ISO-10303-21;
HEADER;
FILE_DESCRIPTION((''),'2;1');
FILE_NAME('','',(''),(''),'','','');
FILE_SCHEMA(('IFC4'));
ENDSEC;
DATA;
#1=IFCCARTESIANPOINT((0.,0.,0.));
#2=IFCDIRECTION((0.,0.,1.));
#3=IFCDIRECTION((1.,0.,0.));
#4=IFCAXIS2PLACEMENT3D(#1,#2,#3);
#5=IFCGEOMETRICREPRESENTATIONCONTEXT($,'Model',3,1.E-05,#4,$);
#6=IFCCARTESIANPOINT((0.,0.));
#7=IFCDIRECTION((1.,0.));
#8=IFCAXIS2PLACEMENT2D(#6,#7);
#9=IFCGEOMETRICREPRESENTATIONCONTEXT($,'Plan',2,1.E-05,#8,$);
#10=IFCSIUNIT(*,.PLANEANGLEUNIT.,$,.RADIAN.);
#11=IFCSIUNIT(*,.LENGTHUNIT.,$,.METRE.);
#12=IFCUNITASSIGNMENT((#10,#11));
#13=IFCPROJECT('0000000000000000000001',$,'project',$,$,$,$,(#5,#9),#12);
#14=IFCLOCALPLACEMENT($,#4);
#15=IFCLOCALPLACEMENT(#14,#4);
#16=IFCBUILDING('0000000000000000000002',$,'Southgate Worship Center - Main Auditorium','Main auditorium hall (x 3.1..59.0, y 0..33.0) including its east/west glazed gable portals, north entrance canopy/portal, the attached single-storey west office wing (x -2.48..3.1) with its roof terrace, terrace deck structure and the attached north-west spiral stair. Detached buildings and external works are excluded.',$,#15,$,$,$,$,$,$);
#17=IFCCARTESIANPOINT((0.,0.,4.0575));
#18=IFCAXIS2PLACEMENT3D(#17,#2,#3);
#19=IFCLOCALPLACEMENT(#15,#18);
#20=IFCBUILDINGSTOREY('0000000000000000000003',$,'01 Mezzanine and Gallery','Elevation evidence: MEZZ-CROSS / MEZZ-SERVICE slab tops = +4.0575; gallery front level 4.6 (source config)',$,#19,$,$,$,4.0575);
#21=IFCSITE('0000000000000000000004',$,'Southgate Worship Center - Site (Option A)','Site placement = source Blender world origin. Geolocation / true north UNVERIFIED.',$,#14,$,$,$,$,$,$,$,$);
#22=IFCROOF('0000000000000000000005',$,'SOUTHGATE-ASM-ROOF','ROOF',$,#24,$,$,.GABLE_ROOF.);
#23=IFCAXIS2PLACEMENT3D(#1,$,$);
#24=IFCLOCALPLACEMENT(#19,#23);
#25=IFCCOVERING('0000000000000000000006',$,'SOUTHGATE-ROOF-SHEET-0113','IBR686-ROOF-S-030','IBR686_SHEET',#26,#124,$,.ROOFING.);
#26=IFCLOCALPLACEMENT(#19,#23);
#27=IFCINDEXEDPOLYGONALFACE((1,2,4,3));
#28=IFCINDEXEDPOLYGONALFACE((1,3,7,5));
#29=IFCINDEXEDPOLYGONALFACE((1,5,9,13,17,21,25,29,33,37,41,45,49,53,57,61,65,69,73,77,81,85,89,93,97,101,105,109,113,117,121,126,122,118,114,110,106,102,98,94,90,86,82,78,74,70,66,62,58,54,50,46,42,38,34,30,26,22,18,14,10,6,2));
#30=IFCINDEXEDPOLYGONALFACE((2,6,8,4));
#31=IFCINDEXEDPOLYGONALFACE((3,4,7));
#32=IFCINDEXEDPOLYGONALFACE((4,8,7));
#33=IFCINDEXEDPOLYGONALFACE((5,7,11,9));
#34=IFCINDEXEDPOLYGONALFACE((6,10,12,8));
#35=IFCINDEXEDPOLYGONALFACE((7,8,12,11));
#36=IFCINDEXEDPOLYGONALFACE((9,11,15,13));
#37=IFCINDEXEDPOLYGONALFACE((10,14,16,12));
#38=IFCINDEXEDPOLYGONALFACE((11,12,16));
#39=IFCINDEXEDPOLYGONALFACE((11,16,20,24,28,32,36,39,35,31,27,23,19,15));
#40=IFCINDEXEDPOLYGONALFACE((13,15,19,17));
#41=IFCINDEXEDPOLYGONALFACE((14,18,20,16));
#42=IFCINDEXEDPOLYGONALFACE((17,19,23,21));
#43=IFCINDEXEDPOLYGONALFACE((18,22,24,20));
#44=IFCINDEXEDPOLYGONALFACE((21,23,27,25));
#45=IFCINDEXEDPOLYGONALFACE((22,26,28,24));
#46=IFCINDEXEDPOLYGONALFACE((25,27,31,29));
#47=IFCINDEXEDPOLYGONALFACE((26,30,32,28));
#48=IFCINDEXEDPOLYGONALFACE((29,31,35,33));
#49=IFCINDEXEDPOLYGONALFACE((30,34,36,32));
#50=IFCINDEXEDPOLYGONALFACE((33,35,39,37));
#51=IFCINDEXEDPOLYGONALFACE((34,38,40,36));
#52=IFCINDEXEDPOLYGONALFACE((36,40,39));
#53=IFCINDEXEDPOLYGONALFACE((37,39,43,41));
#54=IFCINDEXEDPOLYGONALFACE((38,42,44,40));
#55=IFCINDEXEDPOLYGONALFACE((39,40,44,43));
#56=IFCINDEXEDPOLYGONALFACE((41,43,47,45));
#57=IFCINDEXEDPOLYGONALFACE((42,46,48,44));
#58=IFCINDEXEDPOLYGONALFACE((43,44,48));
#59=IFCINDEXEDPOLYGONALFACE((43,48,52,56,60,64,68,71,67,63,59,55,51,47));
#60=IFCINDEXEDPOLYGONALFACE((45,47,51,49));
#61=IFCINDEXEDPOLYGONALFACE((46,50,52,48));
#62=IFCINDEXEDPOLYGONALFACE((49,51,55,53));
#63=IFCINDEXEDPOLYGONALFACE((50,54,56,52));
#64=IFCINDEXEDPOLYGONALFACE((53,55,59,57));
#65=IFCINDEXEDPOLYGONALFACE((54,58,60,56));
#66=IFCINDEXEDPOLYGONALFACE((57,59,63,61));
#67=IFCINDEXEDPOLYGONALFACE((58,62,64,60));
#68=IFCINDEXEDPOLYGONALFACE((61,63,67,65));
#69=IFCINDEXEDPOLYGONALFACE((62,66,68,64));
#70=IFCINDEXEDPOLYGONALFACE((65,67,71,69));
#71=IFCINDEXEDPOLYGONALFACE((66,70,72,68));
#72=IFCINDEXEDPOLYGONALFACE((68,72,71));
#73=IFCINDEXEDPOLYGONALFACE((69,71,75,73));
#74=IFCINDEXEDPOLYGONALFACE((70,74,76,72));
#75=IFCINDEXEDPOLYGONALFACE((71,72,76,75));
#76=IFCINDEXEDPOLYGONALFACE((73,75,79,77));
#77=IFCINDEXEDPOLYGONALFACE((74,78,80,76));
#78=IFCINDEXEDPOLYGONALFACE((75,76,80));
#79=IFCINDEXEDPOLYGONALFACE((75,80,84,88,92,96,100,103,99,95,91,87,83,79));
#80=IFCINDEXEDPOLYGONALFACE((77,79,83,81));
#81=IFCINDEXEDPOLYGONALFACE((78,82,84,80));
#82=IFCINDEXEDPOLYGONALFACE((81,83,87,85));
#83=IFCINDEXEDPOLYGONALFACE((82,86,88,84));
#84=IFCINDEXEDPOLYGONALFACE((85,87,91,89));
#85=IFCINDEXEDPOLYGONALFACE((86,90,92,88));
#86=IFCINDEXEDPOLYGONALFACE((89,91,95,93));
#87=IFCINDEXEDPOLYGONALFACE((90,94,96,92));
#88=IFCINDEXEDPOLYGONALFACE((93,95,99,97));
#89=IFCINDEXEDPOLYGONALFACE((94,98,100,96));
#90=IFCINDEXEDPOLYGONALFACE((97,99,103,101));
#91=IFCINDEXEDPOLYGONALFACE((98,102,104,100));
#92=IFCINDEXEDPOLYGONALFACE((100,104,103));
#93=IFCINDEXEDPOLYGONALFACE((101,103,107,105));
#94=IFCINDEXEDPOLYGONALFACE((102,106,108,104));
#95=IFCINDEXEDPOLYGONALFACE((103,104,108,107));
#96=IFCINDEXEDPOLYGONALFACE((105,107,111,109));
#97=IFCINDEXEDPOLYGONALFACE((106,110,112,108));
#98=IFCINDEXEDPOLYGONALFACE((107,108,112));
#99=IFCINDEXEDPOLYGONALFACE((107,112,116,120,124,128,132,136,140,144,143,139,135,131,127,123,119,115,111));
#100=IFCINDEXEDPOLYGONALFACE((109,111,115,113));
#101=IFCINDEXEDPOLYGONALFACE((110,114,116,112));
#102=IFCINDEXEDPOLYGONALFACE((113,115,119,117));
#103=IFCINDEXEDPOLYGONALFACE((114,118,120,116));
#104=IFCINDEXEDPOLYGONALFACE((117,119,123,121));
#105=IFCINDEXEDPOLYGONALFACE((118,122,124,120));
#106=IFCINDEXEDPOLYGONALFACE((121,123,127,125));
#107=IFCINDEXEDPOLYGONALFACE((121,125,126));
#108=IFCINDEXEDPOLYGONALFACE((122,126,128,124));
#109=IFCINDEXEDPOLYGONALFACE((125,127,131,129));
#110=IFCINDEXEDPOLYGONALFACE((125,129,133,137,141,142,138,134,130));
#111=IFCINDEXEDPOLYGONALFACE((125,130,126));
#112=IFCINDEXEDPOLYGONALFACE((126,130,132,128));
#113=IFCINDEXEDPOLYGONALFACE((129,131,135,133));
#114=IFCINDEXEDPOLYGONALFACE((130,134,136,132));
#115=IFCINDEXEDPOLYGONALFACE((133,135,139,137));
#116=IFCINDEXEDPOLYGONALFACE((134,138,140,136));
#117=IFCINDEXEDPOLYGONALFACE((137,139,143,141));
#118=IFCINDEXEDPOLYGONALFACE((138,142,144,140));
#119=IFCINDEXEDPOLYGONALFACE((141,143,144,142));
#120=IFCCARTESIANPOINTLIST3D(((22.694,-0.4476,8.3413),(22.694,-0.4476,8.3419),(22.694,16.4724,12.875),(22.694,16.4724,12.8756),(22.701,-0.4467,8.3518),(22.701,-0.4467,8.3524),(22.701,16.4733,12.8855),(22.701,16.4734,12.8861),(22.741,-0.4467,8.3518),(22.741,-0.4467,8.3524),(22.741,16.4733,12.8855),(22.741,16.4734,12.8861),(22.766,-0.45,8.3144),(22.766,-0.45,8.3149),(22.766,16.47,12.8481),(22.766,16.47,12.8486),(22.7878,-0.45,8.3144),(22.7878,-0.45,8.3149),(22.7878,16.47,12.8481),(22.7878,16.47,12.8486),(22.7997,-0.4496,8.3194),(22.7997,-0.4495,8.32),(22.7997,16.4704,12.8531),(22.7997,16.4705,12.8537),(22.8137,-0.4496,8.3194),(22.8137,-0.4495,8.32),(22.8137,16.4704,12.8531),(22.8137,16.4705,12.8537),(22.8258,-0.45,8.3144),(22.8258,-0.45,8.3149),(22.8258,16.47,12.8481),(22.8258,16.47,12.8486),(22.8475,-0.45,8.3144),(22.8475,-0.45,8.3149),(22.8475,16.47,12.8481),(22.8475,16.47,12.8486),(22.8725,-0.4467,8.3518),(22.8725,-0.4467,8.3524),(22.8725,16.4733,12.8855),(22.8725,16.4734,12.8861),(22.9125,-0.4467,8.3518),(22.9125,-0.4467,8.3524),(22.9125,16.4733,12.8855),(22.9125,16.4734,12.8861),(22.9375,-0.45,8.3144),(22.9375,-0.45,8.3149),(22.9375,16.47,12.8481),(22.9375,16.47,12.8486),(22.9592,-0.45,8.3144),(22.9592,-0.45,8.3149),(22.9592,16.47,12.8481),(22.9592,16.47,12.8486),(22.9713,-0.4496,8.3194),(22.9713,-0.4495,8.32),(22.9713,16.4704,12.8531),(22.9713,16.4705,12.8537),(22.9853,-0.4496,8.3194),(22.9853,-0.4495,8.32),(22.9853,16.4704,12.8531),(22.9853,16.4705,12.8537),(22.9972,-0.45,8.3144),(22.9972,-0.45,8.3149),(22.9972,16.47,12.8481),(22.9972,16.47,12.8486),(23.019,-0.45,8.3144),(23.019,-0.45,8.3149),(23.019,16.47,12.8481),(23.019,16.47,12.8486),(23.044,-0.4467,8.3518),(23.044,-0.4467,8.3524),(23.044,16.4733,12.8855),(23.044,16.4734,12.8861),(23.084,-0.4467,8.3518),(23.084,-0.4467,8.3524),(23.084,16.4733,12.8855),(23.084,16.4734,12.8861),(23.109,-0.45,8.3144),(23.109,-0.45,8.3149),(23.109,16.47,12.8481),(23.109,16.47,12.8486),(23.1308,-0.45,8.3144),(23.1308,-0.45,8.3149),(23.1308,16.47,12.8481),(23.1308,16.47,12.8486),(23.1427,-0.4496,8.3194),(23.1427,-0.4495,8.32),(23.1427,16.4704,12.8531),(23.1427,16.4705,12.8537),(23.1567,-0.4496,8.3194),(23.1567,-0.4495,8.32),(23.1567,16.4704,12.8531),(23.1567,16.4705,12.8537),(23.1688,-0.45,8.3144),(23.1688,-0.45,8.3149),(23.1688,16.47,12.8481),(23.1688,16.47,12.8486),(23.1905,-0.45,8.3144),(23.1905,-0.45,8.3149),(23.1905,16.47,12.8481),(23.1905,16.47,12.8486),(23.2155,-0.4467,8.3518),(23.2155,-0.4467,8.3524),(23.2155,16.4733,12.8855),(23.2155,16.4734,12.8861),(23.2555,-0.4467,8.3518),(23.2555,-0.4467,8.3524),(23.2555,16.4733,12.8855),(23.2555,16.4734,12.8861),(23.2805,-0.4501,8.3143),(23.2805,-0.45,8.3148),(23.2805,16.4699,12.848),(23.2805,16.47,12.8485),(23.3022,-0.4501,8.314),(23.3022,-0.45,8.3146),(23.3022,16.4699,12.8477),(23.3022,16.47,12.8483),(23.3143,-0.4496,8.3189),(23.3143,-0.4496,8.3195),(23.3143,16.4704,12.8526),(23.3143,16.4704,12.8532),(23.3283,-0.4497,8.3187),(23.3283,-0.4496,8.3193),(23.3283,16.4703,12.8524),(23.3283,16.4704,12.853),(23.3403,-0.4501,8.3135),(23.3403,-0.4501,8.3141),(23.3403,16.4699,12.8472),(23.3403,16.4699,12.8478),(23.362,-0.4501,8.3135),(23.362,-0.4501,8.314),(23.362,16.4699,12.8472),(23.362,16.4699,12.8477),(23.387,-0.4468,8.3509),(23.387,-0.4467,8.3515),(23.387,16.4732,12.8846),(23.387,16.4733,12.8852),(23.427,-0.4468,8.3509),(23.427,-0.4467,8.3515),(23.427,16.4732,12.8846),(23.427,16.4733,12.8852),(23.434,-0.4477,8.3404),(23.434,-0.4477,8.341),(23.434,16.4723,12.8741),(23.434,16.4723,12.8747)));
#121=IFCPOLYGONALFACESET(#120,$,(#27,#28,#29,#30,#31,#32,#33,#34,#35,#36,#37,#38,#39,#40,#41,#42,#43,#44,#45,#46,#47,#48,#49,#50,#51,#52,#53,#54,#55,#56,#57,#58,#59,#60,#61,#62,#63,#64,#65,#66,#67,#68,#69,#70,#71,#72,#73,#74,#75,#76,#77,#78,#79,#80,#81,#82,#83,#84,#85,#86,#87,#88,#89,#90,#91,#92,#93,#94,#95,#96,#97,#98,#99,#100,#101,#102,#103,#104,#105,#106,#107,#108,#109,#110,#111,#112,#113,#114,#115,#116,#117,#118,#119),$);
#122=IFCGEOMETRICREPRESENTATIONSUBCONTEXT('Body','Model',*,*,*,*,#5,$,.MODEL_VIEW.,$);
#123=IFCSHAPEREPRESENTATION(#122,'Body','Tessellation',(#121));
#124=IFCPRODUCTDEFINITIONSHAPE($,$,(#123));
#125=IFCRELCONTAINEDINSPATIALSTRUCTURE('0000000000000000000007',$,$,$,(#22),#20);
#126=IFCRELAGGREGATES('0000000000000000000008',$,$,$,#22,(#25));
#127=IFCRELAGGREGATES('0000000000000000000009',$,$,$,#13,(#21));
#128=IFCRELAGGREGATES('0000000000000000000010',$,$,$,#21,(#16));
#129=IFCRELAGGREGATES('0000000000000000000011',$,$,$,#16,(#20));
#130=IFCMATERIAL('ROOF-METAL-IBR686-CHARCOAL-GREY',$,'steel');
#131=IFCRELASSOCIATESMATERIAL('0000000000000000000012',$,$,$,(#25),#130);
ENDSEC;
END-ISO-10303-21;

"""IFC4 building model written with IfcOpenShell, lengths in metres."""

from ifc_helpers import new_model, si_unit, frame, origin_with_axes, origin_2d_with_axis, place, context, subcontext, project, spatial, indexed_curve, outline, extrude, clip, halfspace, material, element, aggregate, save


model = new_model("IFC4")

# Units and contexts
model_context = context("Model", 3, precision=1e-05, world=origin_with_axes())
plan_context = context("Plan", 2, precision=1e-05, world=origin_2d_with_axis())
body_context = subcontext(model_context, "Body", "Model", "MODEL_VIEW")
ifc_project = project(units=[si_unit("PLANEANGLEUNIT", "RADIAN"), si_unit("LENGTHUNIT", "METRE")], contexts=[model_context, plan_context])

# Site, building, storey
site_placement = place(None, origin_with_axes())
site = spatial("IfcSite", under=ifc_project, at=site_placement, Name="Southgate Worship Center - Site (Option A)", Description="Site placement = source Blender world origin. Geolocation / true north UNVERIFIED.")
building_placement = place(site_placement, origin_with_axes())
building = spatial("IfcBuilding", under=site, at=building_placement, Name="Southgate Worship Center - Main Auditorium", Description="Main auditorium hall (x 3.1..59.0, y 0..33.0) including its east/west glazed gable portals, north entrance canopy/portal, the attached single-storey west office wing (x -2.48..3.1) with its roof terrace, terrace deck structure and the attached north-west spiral stair. Detached buildings and external works are excluded.")
storey_placement = place(building_placement, frame((0.0, 0.0, 4.0575), z_axis=(0.0, 0.0, 1.0), x_axis=(1.0, 0.0, 0.0)))
storey = spatial("IfcBuildingStorey", under=building, at=storey_placement, Name="01 Mezzanine and Gallery", Description="Elevation evidence: MEZZ-CROSS / MEZZ-SERVICE slab tops = +4.0575; gallery front level 4.6 (source config)", Elevation=4.0575)

# Roof, covering
roof_placement = place(storey_placement, origin_with_axes())
roof = element("IfcRoof", 1, at=roof_placement, inside=storey, Name="SOUTHGATE-ASM-ROOF", Description="ROOF", PredefinedType="GABLE_ROOF")
ifc_material_1 = material(Name="ROOF-METAL-IBR686-CHARCOAL-GREY", Category="steel")
covering_1_placement = place(roof_placement, frame((22.694, -0.4501, 8.3135), z_axis=(0.0, 0.0, 1.0), x_axis=(1.0, 0.0, 0.0)))
covering_1 = element("IfcCovering", 2, at=covering_1_placement, material=ifc_material_1, Name="SOUTHGATE-ROOF-SHEET-0113", Description="IBR686-ROOF-S-030", ObjectType="IBR686_SHEET", PredefinedType="ROOFING", context=body_context, shape_type="Clipping", body=[
    clip(clip(extrude(outline(indexed_curve([(0.0, 0.0), (0.025, 0.0353), (0.065, 0.0353), (0.072, 0.0254), (0.072, 0.0259), (0.065, 0.0358), (0.025, 0.0358), (0.0, 0.0005), (-0.0217, 0.0005), (-0.0337, 0.0053), (-0.0477, 0.0053), (-0.0597, 0.0005), (-0.0815, 0.0005), (-0.1065, 0.0358), (-0.1465, 0.0358), (-0.1715, 0.0005), (-0.1932, 0.0005), (-0.2052, 0.0053), (-0.2192, 0.0053), (-0.2312, 0.0005), (-0.253, 0.0005), (-0.278, 0.0358), (-0.318, 0.0358), (-0.343, 0.0005), (-0.3647, 0.0005), (-0.3767, 0.0053), (-0.3907, 0.0053), (-0.4028, 0.0005), (-0.4245, 0.0005), (-0.4495, 0.0358), (-0.4895, 0.0358), (-0.5145, 0.0004), (-0.5362, 0.0002), (-0.5483, 0.0048), (-0.5623, 0.0046), (-0.5742, -0.0003), (-0.596, -0.0004), (-0.621, 0.0349), (-0.661, 0.0349), (-0.668, 0.0251), (-0.668, 0.0246), (-0.661, 0.0344), (-0.621, 0.0344), (-0.596, -0.0009), (-0.5742, -0.0008), (-0.5623, 0.0041), (-0.5483, 0.0043), (-0.5362, -0.0003), (-0.5145, -0.0001), (-0.4895, 0.0353), (-0.4495, 0.0353), (-0.4245, 0.0), (-0.4028, 0.0), (-0.3907, 0.0048), (-0.3767, 0.0048), (-0.3647, 0.0), (-0.343, 0.0), (-0.318, 0.0353), (-0.278, 0.0353), (-0.253, 0.0), (-0.2312, 0.0), (-0.2192, 0.0048), (-0.2052, 0.0048), (-0.1932, 0.0), (-0.1715, 0.0), (-0.1465, 0.0353), (-0.1065, 0.0353), (-0.0815, 0.0), (-0.0597, 0.0), (-0.0477, 0.0048), (-0.0337, 0.0048), (-0.0217, 0.0), (0.0, 0.0)], self_intersect=False)), frame((0.072, -0.0003, 0.0008), z_axis=(0.0, 0.965926, 0.258819), x_axis=(-1.0, 0.0, 0.0)), (0.0, 0.0, 1.0), 17.5303), halfspace(frame((0.37, 0.0012, 0.014), z_axis=(0.0, -0.996022, 0.089113), x_axis=(1.0, 0.0, 0.0)), False)), halfspace(frame((0.37, 16.9212, 4.5477), z_axis=(0.0, 0.996021, -0.089119), x_axis=(-1.0, 0.0, 0.0)), False)),
])
aggregate(roof, [covering_1])

save(model, "model.ifc")
